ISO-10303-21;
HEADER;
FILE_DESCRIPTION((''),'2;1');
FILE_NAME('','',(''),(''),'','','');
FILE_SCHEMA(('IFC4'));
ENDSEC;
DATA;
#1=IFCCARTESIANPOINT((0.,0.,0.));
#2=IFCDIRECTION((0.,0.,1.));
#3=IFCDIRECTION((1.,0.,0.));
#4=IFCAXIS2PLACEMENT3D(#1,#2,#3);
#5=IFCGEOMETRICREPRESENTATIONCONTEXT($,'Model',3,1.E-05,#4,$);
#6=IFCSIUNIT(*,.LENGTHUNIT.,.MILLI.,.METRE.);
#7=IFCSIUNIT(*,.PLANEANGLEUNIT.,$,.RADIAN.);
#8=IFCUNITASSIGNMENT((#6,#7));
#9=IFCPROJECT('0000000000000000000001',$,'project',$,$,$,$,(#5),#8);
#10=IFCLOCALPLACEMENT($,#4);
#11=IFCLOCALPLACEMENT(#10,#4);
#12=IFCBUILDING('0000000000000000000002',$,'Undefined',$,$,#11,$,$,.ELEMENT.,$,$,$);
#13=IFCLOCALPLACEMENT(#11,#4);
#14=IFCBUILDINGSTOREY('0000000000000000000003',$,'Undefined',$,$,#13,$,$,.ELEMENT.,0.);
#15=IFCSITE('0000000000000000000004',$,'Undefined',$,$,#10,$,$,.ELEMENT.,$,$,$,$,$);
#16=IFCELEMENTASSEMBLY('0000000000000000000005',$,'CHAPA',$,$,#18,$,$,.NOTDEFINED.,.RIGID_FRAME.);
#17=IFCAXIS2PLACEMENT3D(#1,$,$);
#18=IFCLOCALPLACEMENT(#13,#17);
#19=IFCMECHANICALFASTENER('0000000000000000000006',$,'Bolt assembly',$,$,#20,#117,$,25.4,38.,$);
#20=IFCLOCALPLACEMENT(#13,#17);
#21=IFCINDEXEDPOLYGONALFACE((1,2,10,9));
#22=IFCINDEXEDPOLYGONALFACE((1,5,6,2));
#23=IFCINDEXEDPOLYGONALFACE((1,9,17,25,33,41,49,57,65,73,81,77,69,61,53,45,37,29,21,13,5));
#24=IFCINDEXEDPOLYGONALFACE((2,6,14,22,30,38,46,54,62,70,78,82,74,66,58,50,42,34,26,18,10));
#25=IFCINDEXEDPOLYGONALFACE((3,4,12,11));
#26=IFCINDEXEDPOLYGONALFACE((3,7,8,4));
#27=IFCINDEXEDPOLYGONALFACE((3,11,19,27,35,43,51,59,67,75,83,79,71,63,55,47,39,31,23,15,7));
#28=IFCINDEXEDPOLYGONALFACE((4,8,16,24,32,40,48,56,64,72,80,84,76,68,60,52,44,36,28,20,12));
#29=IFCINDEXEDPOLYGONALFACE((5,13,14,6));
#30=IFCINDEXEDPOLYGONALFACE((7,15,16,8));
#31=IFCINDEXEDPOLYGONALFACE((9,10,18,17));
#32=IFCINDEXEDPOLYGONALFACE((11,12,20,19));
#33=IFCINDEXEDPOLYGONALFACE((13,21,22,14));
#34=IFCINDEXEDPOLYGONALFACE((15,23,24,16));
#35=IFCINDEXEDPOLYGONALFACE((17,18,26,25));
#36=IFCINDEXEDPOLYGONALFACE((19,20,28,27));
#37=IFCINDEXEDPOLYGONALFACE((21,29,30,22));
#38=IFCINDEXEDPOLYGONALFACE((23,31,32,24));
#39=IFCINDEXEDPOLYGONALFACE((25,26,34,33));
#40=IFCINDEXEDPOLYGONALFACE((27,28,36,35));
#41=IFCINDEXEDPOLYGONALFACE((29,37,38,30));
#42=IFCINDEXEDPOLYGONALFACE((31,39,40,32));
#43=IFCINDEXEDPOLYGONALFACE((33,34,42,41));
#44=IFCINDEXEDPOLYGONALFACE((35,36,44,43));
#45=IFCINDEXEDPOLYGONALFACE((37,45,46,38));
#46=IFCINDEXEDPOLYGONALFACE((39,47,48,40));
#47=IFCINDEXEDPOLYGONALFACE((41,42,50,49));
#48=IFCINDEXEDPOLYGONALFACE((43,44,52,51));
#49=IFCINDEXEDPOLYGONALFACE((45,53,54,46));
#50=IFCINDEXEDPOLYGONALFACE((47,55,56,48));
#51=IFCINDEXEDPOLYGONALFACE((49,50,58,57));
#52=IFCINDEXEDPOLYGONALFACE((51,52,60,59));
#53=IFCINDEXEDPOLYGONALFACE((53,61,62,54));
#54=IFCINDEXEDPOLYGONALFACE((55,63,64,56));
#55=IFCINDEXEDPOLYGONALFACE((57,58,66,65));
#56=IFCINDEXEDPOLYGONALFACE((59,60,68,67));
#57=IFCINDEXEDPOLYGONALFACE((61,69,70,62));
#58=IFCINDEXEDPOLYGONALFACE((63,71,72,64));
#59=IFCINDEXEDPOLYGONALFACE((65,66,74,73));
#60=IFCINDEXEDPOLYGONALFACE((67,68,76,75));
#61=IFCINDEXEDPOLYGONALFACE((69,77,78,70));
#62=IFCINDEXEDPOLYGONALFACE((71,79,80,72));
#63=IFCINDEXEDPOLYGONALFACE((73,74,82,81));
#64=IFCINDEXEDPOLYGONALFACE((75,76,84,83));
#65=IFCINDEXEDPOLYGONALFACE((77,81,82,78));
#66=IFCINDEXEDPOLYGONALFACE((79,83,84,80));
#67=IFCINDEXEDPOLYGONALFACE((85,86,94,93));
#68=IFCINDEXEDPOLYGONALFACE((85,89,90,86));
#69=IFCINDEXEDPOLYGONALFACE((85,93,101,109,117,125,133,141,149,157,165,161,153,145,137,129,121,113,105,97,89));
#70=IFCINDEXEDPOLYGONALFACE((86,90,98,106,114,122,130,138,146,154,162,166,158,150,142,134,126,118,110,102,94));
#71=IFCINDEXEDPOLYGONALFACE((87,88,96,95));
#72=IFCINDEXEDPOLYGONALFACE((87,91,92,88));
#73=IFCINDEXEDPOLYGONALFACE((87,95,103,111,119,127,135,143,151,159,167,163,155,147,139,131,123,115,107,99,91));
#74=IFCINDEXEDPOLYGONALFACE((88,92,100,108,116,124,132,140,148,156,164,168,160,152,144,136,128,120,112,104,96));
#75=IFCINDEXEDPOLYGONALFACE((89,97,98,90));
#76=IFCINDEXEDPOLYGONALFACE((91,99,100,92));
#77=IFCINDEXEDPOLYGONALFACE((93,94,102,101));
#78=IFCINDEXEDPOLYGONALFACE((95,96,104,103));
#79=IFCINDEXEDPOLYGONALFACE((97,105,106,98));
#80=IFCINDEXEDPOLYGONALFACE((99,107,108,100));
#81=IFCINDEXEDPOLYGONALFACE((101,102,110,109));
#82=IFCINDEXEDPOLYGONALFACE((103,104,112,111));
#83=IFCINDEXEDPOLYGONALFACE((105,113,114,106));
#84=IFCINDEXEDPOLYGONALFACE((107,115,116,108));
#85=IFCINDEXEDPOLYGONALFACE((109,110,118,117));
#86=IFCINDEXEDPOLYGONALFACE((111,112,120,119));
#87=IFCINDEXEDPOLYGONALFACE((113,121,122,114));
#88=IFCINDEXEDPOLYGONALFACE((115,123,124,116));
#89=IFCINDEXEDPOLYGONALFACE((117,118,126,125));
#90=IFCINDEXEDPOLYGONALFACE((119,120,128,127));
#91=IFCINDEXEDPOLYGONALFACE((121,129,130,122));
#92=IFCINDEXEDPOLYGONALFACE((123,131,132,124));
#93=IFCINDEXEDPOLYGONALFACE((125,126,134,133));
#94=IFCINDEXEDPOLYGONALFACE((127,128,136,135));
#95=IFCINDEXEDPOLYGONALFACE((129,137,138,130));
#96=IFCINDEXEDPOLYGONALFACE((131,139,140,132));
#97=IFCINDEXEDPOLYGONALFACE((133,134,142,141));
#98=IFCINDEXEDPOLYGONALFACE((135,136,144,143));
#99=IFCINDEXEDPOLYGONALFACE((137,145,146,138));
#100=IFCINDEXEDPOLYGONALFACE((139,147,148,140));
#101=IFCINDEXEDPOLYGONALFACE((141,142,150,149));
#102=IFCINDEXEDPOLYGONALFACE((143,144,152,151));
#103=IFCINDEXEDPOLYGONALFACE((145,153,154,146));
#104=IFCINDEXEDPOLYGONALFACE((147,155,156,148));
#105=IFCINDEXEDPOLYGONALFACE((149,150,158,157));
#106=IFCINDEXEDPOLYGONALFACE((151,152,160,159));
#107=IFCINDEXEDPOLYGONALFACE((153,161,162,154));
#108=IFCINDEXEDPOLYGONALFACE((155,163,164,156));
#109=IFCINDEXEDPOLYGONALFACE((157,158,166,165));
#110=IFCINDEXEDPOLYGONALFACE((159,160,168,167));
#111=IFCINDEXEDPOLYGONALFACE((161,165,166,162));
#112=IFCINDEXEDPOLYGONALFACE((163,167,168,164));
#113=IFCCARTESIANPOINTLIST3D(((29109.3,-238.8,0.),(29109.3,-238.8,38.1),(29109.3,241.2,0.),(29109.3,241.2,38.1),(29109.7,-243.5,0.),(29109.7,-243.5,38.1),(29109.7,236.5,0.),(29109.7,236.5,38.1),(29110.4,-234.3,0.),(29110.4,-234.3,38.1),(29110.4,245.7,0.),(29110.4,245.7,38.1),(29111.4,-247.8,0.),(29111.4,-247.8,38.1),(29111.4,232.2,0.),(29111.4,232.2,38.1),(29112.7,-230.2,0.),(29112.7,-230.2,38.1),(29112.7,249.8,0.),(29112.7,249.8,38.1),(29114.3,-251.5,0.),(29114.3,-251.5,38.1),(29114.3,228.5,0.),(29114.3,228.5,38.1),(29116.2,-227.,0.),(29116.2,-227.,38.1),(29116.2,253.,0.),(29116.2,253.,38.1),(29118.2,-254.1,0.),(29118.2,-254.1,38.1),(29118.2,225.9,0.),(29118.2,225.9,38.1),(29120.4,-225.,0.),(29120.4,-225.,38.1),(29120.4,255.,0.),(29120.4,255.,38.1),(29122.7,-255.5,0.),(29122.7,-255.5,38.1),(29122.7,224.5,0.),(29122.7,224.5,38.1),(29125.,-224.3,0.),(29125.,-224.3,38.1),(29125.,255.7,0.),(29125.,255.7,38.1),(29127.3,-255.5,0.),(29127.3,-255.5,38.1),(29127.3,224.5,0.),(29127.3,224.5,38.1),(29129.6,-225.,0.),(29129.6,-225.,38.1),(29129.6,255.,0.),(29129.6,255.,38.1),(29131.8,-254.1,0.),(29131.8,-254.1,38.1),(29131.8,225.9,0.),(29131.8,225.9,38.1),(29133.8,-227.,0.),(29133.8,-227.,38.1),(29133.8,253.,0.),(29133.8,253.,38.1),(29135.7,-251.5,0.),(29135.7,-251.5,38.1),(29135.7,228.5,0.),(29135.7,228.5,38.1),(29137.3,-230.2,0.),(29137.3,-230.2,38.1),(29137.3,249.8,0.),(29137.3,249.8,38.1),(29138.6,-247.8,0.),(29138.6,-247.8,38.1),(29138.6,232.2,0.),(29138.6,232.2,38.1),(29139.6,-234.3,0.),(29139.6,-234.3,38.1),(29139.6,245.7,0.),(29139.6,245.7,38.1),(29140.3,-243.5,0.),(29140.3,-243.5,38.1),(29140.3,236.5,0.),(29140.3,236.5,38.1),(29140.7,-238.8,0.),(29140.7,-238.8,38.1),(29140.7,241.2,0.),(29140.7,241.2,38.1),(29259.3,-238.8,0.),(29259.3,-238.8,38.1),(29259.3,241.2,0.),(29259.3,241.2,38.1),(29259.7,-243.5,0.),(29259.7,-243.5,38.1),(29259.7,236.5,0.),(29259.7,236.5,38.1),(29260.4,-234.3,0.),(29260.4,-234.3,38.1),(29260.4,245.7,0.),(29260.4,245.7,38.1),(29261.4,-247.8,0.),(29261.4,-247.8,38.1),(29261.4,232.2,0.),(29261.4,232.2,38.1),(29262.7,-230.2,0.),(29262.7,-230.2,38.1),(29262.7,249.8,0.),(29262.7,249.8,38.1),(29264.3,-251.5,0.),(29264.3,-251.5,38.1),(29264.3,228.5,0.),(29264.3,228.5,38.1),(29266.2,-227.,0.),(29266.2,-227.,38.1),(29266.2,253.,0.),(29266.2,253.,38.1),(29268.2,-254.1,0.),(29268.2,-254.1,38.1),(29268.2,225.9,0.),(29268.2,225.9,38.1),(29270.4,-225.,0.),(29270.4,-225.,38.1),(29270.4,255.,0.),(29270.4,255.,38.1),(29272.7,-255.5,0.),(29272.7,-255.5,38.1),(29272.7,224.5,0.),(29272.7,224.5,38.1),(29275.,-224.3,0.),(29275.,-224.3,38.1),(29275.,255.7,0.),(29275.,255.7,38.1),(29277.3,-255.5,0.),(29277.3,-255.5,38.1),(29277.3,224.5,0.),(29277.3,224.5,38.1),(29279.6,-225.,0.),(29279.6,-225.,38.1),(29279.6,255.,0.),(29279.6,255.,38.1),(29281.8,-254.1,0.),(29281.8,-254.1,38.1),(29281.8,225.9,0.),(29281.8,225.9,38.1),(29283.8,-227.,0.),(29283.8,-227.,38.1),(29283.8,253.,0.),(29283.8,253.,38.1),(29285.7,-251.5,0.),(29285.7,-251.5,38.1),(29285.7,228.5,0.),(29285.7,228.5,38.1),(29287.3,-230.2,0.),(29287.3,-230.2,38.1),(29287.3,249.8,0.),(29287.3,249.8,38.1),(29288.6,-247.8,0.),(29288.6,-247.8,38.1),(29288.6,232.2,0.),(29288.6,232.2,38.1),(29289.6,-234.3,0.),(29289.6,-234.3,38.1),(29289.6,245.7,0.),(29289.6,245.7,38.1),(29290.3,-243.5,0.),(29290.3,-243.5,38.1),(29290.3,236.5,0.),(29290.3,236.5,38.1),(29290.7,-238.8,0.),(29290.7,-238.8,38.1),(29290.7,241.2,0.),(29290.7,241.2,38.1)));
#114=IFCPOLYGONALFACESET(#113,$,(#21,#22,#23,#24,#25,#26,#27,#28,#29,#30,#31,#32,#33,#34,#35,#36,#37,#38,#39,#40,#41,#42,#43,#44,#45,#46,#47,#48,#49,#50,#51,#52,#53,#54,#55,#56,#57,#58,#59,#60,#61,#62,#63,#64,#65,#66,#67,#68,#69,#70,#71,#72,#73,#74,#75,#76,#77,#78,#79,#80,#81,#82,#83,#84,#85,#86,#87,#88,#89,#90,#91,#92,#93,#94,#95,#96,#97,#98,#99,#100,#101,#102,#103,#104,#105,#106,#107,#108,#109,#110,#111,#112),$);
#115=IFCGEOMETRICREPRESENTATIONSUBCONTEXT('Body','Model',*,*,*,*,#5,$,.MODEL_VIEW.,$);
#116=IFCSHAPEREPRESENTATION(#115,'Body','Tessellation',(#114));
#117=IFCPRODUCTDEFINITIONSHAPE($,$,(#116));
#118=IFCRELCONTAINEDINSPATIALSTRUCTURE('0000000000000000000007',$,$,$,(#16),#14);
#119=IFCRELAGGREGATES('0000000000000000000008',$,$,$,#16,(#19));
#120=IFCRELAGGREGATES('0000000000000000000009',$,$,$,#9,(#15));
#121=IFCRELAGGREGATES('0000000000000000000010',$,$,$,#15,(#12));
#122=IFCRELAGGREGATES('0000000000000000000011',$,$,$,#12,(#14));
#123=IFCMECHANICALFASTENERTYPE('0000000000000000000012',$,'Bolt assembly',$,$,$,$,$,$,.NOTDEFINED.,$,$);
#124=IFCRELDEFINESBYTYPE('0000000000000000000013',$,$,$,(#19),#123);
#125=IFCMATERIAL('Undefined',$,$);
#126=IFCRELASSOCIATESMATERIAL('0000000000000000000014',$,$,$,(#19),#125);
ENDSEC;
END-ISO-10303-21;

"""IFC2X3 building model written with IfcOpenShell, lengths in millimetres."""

from ifc_helpers import new_model, si_unit, frame, origin_with_axes, origin_2d_with_axis, place, context, subcontext, project, spatial, circle, extrude, source, transform, mapped, material, type_object, element, aggregate, save


model = new_model("IFC2X3")

# Units and contexts
model_context = context("Model", 3, precision=1e-05, world=origin_with_axes())
body_context = subcontext(model_context, "Body", "Model", "MODEL_VIEW")
ifc_project = project(units=[si_unit("LENGTHUNIT", "METRE", prefix="MILLI"), si_unit("PLANEANGLEUNIT", "RADIAN")], contexts=[model_context])

# Site, building, storey
site_placement = place(None, origin_with_axes())
site = spatial("IfcSite", under=ifc_project, at=site_placement, Name="Undefined", CompositionType="ELEMENT")
building_placement = place(site_placement, origin_with_axes())
building = spatial("IfcBuilding", under=site, at=building_placement, Name="Undefined", CompositionType="ELEMENT")
storey_placement = place(building_placement, origin_with_axes())
storey = spatial("IfcBuildingStorey", under=building, at=storey_placement, Name="Undefined", CompositionType="ELEMENT", Elevation=0.0)

# Element assembly
assembly_1_placement = place(storey_placement, origin_with_axes())
assembly_1 = element("IfcElementAssembly", 1, at=assembly_1_placement, inside=storey, Name="CHAPA", AssemblyPlace="NOTDEFINED", PredefinedType="RIGID_FRAME")

# Shared definitions
ifc_material_1 = material(Name="Undefined")
mechanical_fastener_type = type_object("IfcMechanicalFastenerType", Name="Bolt assembly")

# Mechanical fastener
shared_shape_1 = source(origin_with_axes(), body_context, "Body", "SweptSolid", [
    extrude(circle(Radius=15.7, at=origin_2d_with_axis()), frame((0.0, -38.0, 0.0), z_axis=(0.0, 1.0, 0.0), x_axis=(1.0, 0.0, 0.0)), (0.0, 0.0, 1.0), 38.1),
])
mechanical_fastener_1_placement = place(assembly_1_placement, frame((29200.0, -240.0, 38.0), z_axis=(1.0, 0.0, 0.0), x_axis=(0.0, 1.0, 0.0)))
mechanical_fastener_1 = element("IfcMechanicalFastener", 2, at=mechanical_fastener_1_placement, type_object=mechanical_fastener_type, material=ifc_material_1, Name="Bolt assembly", NominalDiameter=25.4, NominalLength=38.0, context=body_context, shape_type="MappedRepresentation", body=[
    mapped(shared_shape_1, transform((0.0, 0.0, -75.0))),
    mapped(shared_shape_1, transform((0.0, 0.0, 75.0))),
    mapped(shared_shape_1, transform((480.0, 0.0, -75.0))),
    mapped(shared_shape_1, transform((480.0, 0.0, 75.0))),
])
aggregate(assembly_1, [mechanical_fastener_1])

save(model, "model.ifc")
